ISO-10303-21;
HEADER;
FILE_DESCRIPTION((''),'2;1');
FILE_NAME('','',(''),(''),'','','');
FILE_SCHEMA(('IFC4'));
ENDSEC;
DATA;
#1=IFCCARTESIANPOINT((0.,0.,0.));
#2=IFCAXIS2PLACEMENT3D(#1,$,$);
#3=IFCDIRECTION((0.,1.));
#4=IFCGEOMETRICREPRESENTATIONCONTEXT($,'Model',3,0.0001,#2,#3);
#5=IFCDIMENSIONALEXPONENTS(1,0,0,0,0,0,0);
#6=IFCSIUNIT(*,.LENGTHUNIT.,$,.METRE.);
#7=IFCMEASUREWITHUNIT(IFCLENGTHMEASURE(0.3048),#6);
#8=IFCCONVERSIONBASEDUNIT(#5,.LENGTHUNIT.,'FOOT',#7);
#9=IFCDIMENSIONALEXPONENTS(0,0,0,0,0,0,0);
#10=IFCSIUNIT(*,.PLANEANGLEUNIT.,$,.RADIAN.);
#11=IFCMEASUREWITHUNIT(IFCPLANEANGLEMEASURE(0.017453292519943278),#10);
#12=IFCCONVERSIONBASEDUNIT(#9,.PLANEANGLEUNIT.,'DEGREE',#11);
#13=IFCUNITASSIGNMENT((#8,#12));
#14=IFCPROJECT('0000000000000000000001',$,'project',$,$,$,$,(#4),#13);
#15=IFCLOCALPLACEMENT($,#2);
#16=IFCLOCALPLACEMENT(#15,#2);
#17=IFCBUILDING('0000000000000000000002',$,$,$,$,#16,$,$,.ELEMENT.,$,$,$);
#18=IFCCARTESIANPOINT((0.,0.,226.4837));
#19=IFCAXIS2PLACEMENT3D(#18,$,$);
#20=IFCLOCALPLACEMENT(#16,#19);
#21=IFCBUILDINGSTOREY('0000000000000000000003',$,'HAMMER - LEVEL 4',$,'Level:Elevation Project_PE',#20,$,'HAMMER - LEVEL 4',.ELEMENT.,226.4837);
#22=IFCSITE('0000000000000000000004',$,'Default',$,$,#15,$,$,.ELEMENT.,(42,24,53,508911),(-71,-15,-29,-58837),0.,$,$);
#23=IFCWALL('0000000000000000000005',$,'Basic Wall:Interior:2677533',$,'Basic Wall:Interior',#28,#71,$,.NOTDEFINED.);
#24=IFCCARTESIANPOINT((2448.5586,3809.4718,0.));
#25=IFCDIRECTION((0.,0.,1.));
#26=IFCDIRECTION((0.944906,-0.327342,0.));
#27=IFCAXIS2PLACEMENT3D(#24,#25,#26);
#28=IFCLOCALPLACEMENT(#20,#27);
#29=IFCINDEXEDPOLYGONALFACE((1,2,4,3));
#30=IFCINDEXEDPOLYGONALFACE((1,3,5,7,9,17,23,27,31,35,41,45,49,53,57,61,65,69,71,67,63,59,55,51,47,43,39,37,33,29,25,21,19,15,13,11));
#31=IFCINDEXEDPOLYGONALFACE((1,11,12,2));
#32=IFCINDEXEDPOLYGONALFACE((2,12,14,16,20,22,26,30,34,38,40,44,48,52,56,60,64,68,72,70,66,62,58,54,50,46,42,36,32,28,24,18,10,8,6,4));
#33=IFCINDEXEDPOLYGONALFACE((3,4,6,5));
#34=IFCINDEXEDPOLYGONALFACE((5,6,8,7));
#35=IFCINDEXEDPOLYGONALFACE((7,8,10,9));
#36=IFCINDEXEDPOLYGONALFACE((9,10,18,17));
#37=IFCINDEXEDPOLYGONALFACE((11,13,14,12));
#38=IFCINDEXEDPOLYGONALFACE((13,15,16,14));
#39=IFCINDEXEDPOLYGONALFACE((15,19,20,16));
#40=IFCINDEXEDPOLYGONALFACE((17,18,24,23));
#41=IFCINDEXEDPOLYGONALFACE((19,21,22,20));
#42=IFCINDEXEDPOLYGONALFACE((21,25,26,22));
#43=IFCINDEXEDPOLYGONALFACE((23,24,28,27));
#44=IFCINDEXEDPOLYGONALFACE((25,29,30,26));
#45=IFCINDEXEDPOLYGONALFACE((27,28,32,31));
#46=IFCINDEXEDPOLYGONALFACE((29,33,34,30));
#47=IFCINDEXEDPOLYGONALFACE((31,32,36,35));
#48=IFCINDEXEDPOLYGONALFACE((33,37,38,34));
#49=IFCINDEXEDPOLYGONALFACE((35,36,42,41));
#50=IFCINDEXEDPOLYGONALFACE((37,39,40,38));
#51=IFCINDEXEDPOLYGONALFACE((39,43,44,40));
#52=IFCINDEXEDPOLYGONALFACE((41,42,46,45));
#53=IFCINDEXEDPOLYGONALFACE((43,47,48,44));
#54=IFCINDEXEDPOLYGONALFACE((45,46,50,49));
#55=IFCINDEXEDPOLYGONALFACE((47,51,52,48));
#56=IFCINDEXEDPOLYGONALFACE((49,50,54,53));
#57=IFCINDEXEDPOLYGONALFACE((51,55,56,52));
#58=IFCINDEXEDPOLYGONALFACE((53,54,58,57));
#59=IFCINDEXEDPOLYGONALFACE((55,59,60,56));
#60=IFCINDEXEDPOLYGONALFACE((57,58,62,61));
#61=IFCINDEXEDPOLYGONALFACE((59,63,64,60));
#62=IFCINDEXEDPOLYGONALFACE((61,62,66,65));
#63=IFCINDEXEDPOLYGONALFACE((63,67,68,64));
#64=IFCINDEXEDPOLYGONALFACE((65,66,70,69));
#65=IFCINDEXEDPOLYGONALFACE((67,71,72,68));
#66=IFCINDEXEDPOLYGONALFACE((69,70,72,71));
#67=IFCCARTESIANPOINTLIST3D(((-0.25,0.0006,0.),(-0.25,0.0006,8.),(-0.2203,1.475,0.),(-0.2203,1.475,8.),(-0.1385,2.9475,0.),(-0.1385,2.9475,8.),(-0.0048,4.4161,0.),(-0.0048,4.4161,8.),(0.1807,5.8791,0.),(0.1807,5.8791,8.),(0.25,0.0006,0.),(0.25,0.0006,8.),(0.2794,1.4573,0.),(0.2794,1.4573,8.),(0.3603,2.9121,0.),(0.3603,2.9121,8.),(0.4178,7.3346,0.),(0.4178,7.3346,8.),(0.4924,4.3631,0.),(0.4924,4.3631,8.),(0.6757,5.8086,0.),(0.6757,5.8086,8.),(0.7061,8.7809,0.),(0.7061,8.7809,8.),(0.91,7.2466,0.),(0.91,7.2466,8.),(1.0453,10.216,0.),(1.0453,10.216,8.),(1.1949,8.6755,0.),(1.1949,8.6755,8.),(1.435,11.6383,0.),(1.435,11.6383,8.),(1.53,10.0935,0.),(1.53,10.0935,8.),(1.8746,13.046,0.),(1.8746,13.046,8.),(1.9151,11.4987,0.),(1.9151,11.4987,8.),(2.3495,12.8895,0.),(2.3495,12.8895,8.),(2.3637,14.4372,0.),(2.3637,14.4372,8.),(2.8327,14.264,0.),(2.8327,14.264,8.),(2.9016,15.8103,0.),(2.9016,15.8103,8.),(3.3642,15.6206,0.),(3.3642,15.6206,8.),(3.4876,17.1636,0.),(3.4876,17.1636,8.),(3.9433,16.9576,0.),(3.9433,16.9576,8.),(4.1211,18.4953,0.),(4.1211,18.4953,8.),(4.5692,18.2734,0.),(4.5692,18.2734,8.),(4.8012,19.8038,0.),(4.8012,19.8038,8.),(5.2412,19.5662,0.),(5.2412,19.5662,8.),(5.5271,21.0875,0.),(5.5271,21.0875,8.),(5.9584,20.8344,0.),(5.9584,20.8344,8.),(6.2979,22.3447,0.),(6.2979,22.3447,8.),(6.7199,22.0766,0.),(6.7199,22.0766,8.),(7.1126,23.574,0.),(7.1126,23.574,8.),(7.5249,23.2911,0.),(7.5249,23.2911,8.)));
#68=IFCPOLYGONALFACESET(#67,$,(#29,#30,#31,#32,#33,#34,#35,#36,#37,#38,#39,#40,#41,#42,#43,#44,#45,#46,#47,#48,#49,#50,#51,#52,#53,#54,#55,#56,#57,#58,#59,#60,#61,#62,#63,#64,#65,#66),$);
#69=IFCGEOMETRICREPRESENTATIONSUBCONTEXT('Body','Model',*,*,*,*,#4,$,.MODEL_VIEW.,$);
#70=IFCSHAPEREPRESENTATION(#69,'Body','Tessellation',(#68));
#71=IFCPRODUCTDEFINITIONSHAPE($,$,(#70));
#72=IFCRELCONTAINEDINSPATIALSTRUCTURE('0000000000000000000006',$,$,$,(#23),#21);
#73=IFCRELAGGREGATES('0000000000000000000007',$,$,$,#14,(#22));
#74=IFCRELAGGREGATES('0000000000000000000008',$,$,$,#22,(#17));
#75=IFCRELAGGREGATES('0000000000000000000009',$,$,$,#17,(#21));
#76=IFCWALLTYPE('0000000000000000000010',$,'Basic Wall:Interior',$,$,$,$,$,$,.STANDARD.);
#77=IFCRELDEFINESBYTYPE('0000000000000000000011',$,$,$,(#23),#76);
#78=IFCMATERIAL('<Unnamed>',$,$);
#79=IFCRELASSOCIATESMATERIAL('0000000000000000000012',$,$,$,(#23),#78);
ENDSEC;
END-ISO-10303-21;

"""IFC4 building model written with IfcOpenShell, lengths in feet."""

from ifc_helpers import new_model, entity, si_unit, converted_unit, direction, frame, origin, place, context, subcontext, project, spatial, line, arc, indexed_curve, outline, extrude, material, type_object, element, save


model = new_model("IFC4")

# Units and contexts
model_context = context("Model", 3, precision=0.0001, world=origin(), true_north=direction((0.0, 1.0)))
body_context = subcontext(model_context, "Body", "Model", "MODEL_VIEW")
ifc_project = project(units=[converted_unit("LENGTHUNIT", "FOOT", entity("IfcLengthMeasure", 0.3048), si_unit("LENGTHUNIT", "METRE"), dimensions=[1, 0, 0, 0, 0, 0, 0]), converted_unit("PLANEANGLEUNIT", "DEGREE", entity("IfcPlaneAngleMeasure", 0.017453292519943278), si_unit("PLANEANGLEUNIT", "RADIAN"), dimensions=[0, 0, 0, 0, 0, 0, 0])], contexts=[model_context])

# Site, building, storey
site_placement = place(None, origin())
site = spatial("IfcSite", under=ifc_project, at=site_placement, Name="Default", CompositionType="ELEMENT", RefLatitude=(42, 24, 53, 508911), RefLongitude=(-71, -15, -29, -58837), RefElevation=0.0)
building_placement = place(site_placement, origin())
building = spatial("IfcBuilding", under=site, at=building_placement, CompositionType="ELEMENT")
storey_placement = place(building_placement, frame((0.0, 0.0, 226.4837)))
storey = spatial("IfcBuildingStorey", under=building, at=storey_placement, Name="HAMMER - LEVEL 4", ObjectType="Level:Elevation Project_PE", LongName="HAMMER - LEVEL 4", CompositionType="ELEMENT", Elevation=226.4837)

# Wall
ifc_material = material(Name="<Unnamed>")
wall_type = type_object("IfcWallType", Name="Basic Wall:Interior", PredefinedType="STANDARD")
wall_1_placement = place(storey_placement, frame((2448.5586, 3809.4718, 0.0), z_axis=(0.0, 0.0, 1.0), x_axis=(0.944906, -0.327342, 0.0)))
element("IfcWall", 1, at=wall_1_placement, inside=storey, type_object=wall_type, material=ifc_material, Name="Basic Wall:Interior:2677533", ObjectType="Basic Wall:Interior", PredefinedType="NOTDEFINED", context=body_context, shape_type="SweptSolid", body=[
    extrude(outline(indexed_curve([(7.1126, 23.574), (1.6486, 12.3441), (-0.25, 0.0006), (0.25, 0.0006), (2.1261, 12.196), (7.5249, 23.2911)], segments=[arc(1, 2, 3), line(3, 4), arc(4, 5, 6), line(6, 1)], self_intersect=False)), origin(), (0.0, 0.0, 1.0), 8.0),
])

save(model, "model.ifc")
